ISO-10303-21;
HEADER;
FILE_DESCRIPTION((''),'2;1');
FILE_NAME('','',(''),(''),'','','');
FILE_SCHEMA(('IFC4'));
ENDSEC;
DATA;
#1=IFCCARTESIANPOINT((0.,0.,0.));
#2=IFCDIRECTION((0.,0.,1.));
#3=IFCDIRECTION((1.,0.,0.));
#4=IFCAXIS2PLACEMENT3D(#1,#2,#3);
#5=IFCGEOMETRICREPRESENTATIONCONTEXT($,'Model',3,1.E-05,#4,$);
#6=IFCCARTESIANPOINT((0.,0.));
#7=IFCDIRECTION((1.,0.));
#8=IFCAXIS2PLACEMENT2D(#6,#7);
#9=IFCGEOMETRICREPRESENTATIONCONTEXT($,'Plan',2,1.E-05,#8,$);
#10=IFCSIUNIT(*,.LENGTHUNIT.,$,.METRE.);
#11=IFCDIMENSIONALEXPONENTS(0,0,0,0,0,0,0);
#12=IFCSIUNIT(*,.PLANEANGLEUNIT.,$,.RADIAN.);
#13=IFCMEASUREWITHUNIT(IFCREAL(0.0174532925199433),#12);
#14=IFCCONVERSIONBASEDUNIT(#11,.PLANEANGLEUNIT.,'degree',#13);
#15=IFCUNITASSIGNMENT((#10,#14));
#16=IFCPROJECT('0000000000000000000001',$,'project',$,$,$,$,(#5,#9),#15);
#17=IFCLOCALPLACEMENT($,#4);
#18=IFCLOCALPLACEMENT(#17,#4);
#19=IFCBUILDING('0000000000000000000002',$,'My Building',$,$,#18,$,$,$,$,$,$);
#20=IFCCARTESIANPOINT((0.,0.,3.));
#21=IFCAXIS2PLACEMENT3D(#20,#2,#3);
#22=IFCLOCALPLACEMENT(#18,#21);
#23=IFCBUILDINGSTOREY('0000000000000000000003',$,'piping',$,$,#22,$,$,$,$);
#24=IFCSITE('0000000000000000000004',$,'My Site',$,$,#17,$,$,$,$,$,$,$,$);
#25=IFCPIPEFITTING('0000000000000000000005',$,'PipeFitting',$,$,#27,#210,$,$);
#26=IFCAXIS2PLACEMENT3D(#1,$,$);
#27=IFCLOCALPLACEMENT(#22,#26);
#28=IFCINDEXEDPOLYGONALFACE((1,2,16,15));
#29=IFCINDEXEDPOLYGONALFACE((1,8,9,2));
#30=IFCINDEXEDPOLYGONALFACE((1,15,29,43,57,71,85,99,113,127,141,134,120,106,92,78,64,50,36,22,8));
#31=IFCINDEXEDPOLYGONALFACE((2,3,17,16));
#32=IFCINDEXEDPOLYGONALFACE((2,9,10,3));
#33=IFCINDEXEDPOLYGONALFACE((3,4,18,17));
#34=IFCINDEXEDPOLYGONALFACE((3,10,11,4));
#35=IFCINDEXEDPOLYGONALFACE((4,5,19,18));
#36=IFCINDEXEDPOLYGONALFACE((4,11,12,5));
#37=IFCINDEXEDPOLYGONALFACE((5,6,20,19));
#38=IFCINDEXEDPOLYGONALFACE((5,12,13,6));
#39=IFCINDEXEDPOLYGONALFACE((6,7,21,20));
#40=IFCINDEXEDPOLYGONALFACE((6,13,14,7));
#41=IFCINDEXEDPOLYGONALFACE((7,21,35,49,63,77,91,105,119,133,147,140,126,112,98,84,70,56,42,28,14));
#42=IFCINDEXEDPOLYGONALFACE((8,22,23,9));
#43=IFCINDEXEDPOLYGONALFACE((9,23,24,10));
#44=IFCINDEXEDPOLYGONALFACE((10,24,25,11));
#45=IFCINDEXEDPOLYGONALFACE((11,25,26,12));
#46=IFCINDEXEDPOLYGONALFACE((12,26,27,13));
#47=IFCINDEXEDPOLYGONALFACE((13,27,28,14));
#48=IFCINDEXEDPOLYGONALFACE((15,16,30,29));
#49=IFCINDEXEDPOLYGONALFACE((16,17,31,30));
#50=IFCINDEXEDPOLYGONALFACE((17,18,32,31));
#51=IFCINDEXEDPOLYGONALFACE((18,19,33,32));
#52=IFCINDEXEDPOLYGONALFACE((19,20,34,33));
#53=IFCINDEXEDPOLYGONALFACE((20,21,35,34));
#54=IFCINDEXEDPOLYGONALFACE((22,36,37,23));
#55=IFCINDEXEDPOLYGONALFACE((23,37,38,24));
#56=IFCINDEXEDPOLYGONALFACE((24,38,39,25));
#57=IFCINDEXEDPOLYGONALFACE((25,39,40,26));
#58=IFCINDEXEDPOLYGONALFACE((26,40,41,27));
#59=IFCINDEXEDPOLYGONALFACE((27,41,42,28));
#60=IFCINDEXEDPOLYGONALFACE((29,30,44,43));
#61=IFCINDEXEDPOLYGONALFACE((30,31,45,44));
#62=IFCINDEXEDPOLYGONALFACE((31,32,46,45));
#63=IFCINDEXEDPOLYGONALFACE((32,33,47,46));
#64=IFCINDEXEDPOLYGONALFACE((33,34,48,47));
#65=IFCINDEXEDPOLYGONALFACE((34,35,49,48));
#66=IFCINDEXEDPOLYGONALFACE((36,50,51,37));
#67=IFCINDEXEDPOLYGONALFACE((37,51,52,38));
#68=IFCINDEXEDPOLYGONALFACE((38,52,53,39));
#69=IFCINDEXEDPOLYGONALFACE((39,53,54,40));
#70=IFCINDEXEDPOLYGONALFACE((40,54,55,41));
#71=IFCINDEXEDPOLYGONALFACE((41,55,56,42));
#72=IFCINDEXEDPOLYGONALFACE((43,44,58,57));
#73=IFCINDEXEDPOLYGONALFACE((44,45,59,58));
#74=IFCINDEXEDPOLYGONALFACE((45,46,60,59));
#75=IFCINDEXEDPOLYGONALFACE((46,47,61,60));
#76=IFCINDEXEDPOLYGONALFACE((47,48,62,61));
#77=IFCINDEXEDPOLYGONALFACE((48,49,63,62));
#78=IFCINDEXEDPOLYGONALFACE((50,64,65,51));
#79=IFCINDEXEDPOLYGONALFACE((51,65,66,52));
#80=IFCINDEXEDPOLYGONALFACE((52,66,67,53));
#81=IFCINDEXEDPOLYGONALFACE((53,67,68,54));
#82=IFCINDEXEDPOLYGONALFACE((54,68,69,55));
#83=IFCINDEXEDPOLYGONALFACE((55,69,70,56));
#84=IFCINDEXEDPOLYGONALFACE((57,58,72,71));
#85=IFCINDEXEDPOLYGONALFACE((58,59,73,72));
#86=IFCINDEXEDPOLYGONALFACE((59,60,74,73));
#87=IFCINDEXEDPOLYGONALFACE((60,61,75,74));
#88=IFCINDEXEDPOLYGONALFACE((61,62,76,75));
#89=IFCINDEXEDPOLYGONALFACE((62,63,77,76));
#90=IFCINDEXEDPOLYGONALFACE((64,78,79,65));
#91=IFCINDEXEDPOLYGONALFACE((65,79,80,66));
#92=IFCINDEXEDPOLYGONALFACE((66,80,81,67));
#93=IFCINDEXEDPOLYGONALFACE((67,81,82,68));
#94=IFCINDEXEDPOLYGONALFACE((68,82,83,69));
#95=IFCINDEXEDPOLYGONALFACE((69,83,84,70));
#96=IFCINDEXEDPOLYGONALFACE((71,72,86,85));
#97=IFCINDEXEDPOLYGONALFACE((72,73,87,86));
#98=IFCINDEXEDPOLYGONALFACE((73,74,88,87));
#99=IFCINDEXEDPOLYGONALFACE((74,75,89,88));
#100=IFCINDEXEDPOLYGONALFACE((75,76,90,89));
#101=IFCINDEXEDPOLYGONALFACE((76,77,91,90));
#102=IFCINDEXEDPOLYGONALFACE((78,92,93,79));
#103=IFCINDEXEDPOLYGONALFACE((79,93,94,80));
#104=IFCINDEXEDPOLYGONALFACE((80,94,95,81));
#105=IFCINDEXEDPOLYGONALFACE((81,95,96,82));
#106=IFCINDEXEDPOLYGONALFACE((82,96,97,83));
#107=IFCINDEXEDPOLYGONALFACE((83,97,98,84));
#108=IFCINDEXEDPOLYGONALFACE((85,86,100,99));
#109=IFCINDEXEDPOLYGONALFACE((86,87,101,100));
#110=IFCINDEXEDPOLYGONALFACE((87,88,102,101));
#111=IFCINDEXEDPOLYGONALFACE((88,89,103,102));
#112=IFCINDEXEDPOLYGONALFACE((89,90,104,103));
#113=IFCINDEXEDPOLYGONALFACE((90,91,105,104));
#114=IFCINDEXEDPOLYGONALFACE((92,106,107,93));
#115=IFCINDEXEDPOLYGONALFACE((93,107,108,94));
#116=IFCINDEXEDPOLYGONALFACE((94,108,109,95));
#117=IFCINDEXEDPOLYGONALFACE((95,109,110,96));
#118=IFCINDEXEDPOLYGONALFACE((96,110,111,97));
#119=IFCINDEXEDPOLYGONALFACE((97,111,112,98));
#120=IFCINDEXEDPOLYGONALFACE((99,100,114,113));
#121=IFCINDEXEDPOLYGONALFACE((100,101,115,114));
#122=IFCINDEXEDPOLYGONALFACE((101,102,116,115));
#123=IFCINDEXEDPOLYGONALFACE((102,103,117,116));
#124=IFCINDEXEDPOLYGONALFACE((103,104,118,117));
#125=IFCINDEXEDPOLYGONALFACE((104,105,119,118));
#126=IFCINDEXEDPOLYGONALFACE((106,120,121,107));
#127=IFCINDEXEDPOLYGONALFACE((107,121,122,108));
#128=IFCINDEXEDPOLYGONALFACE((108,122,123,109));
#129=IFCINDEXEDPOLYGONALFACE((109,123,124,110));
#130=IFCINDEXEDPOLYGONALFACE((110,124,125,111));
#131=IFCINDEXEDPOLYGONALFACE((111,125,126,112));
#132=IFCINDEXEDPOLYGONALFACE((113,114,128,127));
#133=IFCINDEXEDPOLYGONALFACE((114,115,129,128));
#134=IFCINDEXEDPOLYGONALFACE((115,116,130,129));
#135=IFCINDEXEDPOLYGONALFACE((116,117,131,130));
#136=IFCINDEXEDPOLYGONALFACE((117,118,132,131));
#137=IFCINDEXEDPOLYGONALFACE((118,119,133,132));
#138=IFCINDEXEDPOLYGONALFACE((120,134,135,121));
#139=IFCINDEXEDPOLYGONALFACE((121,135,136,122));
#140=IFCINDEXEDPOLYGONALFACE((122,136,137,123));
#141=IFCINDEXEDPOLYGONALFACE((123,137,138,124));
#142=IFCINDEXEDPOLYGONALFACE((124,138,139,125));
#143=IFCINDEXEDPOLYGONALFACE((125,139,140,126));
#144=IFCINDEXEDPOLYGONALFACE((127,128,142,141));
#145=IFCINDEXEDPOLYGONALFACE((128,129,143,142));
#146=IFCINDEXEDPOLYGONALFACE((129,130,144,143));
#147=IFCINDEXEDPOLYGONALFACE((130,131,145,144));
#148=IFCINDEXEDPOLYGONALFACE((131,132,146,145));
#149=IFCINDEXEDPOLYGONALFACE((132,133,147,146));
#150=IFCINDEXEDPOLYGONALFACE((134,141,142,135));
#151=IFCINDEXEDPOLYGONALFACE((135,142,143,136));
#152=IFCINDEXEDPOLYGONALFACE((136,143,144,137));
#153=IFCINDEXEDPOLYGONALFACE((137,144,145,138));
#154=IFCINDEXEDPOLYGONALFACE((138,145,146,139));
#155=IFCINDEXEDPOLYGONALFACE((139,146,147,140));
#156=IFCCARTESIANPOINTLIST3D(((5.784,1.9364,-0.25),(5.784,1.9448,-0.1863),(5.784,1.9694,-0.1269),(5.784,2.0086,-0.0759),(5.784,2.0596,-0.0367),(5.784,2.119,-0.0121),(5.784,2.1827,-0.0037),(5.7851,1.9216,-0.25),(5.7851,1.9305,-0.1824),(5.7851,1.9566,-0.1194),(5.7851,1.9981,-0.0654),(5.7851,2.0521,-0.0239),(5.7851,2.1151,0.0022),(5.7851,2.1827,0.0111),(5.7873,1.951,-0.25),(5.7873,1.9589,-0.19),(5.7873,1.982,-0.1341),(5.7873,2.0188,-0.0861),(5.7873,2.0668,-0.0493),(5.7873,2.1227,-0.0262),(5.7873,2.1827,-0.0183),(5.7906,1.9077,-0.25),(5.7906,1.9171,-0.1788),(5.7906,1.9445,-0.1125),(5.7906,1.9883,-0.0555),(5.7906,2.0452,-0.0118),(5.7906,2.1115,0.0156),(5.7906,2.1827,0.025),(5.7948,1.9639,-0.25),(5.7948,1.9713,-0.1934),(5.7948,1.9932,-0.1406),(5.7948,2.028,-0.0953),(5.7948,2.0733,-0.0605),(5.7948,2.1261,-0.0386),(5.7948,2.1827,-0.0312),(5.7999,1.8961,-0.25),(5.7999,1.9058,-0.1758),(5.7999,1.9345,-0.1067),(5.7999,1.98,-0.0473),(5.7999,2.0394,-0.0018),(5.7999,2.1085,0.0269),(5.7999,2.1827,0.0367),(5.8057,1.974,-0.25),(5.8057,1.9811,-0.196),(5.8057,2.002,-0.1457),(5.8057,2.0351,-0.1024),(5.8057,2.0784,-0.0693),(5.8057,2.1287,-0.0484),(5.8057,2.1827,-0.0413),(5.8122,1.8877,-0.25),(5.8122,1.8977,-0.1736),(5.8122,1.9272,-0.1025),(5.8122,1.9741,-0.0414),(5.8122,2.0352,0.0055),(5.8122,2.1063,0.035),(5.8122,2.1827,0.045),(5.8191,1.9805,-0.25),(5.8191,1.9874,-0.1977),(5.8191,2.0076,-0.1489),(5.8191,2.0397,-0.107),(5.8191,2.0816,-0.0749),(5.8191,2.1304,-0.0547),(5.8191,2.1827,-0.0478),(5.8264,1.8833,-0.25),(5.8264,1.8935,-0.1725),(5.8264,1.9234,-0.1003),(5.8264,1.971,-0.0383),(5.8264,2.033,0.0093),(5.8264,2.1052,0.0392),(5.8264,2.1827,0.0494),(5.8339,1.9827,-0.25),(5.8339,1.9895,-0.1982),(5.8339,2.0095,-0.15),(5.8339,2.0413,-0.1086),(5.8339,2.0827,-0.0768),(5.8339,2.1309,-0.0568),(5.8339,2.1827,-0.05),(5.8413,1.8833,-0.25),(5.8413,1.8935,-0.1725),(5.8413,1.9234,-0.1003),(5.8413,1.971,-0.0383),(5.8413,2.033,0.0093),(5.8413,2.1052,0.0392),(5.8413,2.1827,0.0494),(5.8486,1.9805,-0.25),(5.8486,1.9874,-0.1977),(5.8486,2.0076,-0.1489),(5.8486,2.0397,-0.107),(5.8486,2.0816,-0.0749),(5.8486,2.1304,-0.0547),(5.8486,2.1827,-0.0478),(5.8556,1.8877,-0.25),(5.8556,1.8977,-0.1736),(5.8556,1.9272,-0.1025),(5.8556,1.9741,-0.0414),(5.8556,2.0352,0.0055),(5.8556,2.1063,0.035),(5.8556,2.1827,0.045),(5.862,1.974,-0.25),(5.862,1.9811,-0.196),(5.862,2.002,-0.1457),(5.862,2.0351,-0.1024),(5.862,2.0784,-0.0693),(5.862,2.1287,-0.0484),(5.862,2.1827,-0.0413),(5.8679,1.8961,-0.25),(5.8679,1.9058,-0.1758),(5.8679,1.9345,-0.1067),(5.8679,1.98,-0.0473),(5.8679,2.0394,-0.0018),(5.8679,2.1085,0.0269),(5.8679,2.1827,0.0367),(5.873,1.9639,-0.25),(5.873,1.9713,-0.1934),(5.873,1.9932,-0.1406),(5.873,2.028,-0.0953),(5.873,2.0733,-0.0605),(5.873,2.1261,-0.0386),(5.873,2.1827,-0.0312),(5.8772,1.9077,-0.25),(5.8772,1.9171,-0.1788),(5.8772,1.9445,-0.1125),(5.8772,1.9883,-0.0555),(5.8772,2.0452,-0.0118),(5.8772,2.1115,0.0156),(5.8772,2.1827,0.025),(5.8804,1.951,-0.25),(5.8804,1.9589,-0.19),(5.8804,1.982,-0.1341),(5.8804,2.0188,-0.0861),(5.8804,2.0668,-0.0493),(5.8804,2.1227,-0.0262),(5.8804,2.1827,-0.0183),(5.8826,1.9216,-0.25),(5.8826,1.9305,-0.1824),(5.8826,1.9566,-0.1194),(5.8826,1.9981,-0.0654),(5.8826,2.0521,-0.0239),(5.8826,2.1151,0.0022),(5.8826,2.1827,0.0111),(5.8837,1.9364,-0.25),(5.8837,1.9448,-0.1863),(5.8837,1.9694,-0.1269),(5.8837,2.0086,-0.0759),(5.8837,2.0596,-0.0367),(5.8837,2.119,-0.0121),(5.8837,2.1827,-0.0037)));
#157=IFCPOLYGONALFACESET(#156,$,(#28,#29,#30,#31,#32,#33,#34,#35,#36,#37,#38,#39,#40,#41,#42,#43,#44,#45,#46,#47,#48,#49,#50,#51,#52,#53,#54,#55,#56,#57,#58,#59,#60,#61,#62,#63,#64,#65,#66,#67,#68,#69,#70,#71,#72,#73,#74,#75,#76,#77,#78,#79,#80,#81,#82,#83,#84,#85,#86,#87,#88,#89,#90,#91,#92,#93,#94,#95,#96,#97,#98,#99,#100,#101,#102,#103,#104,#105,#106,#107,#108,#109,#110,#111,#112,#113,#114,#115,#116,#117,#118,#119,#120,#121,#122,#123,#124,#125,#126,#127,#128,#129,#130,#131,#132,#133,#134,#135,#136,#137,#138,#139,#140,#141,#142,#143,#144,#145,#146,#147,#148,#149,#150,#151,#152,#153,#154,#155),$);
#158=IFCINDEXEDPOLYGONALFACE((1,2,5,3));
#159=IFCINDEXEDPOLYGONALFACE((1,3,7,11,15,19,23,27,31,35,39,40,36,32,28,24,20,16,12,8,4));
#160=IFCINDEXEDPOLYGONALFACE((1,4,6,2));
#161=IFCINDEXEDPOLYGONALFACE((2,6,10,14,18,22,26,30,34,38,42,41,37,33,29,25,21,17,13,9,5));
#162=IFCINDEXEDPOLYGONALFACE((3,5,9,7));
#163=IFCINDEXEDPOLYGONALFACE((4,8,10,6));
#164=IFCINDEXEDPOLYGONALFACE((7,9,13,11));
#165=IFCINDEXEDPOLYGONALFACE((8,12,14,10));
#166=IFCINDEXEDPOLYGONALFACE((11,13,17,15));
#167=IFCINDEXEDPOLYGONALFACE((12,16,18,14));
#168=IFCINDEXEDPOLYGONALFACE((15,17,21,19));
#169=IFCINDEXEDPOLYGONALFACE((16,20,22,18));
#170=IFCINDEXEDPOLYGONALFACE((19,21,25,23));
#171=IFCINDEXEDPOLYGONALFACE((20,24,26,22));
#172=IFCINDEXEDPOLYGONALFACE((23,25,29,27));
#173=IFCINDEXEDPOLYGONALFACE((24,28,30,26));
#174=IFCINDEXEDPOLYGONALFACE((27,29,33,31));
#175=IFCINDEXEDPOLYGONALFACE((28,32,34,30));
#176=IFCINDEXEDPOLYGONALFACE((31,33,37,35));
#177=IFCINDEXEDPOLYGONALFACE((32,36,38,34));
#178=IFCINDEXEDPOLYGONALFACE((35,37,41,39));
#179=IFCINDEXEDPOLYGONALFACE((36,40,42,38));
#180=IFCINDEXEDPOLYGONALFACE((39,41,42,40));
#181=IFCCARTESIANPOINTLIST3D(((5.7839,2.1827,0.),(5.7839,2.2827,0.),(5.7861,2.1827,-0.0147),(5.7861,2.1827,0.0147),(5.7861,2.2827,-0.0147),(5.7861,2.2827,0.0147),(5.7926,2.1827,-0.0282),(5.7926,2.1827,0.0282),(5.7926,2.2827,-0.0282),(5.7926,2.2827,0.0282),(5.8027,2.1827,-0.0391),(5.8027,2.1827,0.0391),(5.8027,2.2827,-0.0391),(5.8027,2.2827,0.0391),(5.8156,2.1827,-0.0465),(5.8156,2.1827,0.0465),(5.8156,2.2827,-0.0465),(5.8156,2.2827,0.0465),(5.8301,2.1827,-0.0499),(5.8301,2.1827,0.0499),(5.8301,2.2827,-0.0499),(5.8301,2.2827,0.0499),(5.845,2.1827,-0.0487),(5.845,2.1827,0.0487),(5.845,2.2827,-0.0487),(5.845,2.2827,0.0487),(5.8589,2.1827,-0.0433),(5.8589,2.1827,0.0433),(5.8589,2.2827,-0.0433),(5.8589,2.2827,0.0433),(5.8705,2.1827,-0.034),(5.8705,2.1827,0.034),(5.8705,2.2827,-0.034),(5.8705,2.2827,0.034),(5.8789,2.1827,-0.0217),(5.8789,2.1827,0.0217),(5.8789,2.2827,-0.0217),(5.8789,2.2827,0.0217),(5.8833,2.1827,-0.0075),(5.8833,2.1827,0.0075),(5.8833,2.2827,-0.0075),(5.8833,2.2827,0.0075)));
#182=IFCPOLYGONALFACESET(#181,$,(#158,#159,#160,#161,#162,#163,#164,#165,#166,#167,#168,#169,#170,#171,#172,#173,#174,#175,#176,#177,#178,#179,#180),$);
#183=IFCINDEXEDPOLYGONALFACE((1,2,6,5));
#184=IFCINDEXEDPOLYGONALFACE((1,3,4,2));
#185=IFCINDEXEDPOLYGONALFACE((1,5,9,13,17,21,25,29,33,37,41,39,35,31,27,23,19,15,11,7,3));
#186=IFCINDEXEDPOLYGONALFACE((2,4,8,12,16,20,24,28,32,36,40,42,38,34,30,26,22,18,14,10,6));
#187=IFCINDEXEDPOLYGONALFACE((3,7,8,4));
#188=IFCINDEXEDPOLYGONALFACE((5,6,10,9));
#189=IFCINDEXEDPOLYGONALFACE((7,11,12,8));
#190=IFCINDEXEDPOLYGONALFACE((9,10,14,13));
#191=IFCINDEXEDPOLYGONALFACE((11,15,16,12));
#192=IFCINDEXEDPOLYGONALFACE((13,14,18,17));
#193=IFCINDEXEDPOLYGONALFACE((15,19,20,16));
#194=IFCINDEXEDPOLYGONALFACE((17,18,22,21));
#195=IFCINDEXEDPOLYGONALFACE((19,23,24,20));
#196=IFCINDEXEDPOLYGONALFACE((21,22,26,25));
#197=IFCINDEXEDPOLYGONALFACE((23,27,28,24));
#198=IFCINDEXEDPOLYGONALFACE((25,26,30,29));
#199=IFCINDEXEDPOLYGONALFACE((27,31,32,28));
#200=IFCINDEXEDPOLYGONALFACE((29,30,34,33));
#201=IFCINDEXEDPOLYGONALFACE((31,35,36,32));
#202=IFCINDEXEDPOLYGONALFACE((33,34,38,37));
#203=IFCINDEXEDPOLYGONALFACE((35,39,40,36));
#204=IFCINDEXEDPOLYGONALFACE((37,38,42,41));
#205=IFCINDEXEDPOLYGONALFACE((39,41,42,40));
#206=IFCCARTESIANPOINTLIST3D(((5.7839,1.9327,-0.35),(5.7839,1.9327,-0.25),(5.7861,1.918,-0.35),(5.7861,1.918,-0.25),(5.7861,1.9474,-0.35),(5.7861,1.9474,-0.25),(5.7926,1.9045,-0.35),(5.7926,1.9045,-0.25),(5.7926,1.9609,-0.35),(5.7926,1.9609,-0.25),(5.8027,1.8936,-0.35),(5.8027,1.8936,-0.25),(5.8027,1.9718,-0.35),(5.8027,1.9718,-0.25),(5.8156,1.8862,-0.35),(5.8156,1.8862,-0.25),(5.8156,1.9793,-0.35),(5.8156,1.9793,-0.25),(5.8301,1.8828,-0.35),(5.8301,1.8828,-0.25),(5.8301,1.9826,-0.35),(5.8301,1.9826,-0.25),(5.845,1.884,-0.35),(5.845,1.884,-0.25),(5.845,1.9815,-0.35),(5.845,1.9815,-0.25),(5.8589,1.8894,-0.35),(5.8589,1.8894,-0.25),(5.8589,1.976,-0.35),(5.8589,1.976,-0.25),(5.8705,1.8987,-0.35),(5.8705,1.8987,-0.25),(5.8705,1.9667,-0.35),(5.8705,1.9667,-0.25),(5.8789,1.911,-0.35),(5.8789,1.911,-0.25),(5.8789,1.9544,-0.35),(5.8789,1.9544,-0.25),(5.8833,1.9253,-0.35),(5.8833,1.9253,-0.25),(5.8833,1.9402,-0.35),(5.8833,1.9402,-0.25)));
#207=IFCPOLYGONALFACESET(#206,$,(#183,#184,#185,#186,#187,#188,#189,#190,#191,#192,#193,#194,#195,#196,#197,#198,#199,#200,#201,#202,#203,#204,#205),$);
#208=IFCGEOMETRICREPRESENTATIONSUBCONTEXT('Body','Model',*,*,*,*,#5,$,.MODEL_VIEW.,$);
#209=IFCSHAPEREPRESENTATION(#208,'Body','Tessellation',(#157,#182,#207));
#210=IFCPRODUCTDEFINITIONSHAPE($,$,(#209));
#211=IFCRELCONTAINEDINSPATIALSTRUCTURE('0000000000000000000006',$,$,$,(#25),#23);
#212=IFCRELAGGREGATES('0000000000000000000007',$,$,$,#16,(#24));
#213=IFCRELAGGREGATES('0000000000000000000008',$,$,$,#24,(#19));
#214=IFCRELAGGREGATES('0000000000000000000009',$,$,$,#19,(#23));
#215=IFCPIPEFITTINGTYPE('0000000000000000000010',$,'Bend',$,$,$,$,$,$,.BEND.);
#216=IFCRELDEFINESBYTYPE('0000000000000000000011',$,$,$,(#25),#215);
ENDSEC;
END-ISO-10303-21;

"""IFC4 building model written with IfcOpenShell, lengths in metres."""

from ifc_helpers import new_model, entity, si_unit, converted_unit, frame, origin_with_axes, origin_2d_with_axis, place, context, subcontext, project, spatial, circle, extrude, source, transform, mapped, type_object, type_shapes, element, save


model = new_model("IFC4")

# Units and contexts
model_context = context("Model", 3, precision=1e-05, world=origin_with_axes())
plan_context = context("Plan", 2, precision=1e-05, world=origin_2d_with_axis())
body_context = subcontext(model_context, "Body", "Model", "MODEL_VIEW")
ifc_project = project(units=[si_unit("LENGTHUNIT", "METRE"), converted_unit("PLANEANGLEUNIT", "degree", entity("IfcReal", 0.0174532925199433), si_unit("PLANEANGLEUNIT", "RADIAN"), dimensions=[0, 0, 0, 0, 0, 0, 0])], contexts=[model_context, plan_context])

# Site, building, storey
site_placement = place(None, origin_with_axes())
site = spatial("IfcSite", under=ifc_project, at=site_placement, Name="My Site")
building_placement = place(site_placement, origin_with_axes())
building = spatial("IfcBuilding", under=site, at=building_placement, Name="My Building")
storey_placement = place(building_placement, frame((0.0, 0.0, 3.0), z_axis=(0.0, 0.0, 1.0), x_axis=(1.0, 0.0, 0.0)))
storey = spatial("IfcBuildingStorey", under=building, at=storey_placement, Name="piping")

# Pipe fitting
pipe_fitting_type = type_object("IfcPipeFittingType", Name="Bend", PredefinedType="BEND")
shared_shape = source(origin_with_axes(), body_context, "Body", "SolidModel", [
    entity("IfcSweptDiskSolid", entity("IfcIndexedPolyCurve", entity("IfcCartesianPointList3D", [[0.0, 0.0, -0.1], [0.0, -0.0732, -0.2768], [0.0, -0.25, -0.35]]), [entity("IfcArcIndex", [1, 2, 3])]), 0.05),
    extrude(circle(Radius=0.05), origin_with_axes(), (0.0, 0.0, -1.0), 0.1),
    extrude(circle(Radius=0.05), frame((0.0, -0.25, -0.35), z_axis=(0.0, -1.0, 0.0), x_axis=(1.0, 0.0, 0.0)), (0.0, 0.0, 1.0), 0.1),
])
type_shapes(pipe_fitting_type, [shared_shape])
for number, where, z_axis, x_axis, name in (
    (1, (5.8339, 2.2827, 0.0), (0.0, 1.0, 0.0), (-1.0, 0.0, 0.0), "PipeFitting"),
):
    element("IfcPipeFitting", number, at=place(storey_placement, frame(where, z_axis=z_axis, x_axis=x_axis)), inside=storey, type_object=pipe_fitting_type, Name=name, context=body_context, shape_type="MappedRepresentation", body=[
        mapped(shared_shape, transform((0.0, 0.0, 0.0), x_axis=(1.0, 0.0, 0.0), y_axis=(0.0, 1.0, 0.0), z_axis=(0.0, 0.0, 1.0), scale=1.0)),
    ])

save(model, "model.ifc")
